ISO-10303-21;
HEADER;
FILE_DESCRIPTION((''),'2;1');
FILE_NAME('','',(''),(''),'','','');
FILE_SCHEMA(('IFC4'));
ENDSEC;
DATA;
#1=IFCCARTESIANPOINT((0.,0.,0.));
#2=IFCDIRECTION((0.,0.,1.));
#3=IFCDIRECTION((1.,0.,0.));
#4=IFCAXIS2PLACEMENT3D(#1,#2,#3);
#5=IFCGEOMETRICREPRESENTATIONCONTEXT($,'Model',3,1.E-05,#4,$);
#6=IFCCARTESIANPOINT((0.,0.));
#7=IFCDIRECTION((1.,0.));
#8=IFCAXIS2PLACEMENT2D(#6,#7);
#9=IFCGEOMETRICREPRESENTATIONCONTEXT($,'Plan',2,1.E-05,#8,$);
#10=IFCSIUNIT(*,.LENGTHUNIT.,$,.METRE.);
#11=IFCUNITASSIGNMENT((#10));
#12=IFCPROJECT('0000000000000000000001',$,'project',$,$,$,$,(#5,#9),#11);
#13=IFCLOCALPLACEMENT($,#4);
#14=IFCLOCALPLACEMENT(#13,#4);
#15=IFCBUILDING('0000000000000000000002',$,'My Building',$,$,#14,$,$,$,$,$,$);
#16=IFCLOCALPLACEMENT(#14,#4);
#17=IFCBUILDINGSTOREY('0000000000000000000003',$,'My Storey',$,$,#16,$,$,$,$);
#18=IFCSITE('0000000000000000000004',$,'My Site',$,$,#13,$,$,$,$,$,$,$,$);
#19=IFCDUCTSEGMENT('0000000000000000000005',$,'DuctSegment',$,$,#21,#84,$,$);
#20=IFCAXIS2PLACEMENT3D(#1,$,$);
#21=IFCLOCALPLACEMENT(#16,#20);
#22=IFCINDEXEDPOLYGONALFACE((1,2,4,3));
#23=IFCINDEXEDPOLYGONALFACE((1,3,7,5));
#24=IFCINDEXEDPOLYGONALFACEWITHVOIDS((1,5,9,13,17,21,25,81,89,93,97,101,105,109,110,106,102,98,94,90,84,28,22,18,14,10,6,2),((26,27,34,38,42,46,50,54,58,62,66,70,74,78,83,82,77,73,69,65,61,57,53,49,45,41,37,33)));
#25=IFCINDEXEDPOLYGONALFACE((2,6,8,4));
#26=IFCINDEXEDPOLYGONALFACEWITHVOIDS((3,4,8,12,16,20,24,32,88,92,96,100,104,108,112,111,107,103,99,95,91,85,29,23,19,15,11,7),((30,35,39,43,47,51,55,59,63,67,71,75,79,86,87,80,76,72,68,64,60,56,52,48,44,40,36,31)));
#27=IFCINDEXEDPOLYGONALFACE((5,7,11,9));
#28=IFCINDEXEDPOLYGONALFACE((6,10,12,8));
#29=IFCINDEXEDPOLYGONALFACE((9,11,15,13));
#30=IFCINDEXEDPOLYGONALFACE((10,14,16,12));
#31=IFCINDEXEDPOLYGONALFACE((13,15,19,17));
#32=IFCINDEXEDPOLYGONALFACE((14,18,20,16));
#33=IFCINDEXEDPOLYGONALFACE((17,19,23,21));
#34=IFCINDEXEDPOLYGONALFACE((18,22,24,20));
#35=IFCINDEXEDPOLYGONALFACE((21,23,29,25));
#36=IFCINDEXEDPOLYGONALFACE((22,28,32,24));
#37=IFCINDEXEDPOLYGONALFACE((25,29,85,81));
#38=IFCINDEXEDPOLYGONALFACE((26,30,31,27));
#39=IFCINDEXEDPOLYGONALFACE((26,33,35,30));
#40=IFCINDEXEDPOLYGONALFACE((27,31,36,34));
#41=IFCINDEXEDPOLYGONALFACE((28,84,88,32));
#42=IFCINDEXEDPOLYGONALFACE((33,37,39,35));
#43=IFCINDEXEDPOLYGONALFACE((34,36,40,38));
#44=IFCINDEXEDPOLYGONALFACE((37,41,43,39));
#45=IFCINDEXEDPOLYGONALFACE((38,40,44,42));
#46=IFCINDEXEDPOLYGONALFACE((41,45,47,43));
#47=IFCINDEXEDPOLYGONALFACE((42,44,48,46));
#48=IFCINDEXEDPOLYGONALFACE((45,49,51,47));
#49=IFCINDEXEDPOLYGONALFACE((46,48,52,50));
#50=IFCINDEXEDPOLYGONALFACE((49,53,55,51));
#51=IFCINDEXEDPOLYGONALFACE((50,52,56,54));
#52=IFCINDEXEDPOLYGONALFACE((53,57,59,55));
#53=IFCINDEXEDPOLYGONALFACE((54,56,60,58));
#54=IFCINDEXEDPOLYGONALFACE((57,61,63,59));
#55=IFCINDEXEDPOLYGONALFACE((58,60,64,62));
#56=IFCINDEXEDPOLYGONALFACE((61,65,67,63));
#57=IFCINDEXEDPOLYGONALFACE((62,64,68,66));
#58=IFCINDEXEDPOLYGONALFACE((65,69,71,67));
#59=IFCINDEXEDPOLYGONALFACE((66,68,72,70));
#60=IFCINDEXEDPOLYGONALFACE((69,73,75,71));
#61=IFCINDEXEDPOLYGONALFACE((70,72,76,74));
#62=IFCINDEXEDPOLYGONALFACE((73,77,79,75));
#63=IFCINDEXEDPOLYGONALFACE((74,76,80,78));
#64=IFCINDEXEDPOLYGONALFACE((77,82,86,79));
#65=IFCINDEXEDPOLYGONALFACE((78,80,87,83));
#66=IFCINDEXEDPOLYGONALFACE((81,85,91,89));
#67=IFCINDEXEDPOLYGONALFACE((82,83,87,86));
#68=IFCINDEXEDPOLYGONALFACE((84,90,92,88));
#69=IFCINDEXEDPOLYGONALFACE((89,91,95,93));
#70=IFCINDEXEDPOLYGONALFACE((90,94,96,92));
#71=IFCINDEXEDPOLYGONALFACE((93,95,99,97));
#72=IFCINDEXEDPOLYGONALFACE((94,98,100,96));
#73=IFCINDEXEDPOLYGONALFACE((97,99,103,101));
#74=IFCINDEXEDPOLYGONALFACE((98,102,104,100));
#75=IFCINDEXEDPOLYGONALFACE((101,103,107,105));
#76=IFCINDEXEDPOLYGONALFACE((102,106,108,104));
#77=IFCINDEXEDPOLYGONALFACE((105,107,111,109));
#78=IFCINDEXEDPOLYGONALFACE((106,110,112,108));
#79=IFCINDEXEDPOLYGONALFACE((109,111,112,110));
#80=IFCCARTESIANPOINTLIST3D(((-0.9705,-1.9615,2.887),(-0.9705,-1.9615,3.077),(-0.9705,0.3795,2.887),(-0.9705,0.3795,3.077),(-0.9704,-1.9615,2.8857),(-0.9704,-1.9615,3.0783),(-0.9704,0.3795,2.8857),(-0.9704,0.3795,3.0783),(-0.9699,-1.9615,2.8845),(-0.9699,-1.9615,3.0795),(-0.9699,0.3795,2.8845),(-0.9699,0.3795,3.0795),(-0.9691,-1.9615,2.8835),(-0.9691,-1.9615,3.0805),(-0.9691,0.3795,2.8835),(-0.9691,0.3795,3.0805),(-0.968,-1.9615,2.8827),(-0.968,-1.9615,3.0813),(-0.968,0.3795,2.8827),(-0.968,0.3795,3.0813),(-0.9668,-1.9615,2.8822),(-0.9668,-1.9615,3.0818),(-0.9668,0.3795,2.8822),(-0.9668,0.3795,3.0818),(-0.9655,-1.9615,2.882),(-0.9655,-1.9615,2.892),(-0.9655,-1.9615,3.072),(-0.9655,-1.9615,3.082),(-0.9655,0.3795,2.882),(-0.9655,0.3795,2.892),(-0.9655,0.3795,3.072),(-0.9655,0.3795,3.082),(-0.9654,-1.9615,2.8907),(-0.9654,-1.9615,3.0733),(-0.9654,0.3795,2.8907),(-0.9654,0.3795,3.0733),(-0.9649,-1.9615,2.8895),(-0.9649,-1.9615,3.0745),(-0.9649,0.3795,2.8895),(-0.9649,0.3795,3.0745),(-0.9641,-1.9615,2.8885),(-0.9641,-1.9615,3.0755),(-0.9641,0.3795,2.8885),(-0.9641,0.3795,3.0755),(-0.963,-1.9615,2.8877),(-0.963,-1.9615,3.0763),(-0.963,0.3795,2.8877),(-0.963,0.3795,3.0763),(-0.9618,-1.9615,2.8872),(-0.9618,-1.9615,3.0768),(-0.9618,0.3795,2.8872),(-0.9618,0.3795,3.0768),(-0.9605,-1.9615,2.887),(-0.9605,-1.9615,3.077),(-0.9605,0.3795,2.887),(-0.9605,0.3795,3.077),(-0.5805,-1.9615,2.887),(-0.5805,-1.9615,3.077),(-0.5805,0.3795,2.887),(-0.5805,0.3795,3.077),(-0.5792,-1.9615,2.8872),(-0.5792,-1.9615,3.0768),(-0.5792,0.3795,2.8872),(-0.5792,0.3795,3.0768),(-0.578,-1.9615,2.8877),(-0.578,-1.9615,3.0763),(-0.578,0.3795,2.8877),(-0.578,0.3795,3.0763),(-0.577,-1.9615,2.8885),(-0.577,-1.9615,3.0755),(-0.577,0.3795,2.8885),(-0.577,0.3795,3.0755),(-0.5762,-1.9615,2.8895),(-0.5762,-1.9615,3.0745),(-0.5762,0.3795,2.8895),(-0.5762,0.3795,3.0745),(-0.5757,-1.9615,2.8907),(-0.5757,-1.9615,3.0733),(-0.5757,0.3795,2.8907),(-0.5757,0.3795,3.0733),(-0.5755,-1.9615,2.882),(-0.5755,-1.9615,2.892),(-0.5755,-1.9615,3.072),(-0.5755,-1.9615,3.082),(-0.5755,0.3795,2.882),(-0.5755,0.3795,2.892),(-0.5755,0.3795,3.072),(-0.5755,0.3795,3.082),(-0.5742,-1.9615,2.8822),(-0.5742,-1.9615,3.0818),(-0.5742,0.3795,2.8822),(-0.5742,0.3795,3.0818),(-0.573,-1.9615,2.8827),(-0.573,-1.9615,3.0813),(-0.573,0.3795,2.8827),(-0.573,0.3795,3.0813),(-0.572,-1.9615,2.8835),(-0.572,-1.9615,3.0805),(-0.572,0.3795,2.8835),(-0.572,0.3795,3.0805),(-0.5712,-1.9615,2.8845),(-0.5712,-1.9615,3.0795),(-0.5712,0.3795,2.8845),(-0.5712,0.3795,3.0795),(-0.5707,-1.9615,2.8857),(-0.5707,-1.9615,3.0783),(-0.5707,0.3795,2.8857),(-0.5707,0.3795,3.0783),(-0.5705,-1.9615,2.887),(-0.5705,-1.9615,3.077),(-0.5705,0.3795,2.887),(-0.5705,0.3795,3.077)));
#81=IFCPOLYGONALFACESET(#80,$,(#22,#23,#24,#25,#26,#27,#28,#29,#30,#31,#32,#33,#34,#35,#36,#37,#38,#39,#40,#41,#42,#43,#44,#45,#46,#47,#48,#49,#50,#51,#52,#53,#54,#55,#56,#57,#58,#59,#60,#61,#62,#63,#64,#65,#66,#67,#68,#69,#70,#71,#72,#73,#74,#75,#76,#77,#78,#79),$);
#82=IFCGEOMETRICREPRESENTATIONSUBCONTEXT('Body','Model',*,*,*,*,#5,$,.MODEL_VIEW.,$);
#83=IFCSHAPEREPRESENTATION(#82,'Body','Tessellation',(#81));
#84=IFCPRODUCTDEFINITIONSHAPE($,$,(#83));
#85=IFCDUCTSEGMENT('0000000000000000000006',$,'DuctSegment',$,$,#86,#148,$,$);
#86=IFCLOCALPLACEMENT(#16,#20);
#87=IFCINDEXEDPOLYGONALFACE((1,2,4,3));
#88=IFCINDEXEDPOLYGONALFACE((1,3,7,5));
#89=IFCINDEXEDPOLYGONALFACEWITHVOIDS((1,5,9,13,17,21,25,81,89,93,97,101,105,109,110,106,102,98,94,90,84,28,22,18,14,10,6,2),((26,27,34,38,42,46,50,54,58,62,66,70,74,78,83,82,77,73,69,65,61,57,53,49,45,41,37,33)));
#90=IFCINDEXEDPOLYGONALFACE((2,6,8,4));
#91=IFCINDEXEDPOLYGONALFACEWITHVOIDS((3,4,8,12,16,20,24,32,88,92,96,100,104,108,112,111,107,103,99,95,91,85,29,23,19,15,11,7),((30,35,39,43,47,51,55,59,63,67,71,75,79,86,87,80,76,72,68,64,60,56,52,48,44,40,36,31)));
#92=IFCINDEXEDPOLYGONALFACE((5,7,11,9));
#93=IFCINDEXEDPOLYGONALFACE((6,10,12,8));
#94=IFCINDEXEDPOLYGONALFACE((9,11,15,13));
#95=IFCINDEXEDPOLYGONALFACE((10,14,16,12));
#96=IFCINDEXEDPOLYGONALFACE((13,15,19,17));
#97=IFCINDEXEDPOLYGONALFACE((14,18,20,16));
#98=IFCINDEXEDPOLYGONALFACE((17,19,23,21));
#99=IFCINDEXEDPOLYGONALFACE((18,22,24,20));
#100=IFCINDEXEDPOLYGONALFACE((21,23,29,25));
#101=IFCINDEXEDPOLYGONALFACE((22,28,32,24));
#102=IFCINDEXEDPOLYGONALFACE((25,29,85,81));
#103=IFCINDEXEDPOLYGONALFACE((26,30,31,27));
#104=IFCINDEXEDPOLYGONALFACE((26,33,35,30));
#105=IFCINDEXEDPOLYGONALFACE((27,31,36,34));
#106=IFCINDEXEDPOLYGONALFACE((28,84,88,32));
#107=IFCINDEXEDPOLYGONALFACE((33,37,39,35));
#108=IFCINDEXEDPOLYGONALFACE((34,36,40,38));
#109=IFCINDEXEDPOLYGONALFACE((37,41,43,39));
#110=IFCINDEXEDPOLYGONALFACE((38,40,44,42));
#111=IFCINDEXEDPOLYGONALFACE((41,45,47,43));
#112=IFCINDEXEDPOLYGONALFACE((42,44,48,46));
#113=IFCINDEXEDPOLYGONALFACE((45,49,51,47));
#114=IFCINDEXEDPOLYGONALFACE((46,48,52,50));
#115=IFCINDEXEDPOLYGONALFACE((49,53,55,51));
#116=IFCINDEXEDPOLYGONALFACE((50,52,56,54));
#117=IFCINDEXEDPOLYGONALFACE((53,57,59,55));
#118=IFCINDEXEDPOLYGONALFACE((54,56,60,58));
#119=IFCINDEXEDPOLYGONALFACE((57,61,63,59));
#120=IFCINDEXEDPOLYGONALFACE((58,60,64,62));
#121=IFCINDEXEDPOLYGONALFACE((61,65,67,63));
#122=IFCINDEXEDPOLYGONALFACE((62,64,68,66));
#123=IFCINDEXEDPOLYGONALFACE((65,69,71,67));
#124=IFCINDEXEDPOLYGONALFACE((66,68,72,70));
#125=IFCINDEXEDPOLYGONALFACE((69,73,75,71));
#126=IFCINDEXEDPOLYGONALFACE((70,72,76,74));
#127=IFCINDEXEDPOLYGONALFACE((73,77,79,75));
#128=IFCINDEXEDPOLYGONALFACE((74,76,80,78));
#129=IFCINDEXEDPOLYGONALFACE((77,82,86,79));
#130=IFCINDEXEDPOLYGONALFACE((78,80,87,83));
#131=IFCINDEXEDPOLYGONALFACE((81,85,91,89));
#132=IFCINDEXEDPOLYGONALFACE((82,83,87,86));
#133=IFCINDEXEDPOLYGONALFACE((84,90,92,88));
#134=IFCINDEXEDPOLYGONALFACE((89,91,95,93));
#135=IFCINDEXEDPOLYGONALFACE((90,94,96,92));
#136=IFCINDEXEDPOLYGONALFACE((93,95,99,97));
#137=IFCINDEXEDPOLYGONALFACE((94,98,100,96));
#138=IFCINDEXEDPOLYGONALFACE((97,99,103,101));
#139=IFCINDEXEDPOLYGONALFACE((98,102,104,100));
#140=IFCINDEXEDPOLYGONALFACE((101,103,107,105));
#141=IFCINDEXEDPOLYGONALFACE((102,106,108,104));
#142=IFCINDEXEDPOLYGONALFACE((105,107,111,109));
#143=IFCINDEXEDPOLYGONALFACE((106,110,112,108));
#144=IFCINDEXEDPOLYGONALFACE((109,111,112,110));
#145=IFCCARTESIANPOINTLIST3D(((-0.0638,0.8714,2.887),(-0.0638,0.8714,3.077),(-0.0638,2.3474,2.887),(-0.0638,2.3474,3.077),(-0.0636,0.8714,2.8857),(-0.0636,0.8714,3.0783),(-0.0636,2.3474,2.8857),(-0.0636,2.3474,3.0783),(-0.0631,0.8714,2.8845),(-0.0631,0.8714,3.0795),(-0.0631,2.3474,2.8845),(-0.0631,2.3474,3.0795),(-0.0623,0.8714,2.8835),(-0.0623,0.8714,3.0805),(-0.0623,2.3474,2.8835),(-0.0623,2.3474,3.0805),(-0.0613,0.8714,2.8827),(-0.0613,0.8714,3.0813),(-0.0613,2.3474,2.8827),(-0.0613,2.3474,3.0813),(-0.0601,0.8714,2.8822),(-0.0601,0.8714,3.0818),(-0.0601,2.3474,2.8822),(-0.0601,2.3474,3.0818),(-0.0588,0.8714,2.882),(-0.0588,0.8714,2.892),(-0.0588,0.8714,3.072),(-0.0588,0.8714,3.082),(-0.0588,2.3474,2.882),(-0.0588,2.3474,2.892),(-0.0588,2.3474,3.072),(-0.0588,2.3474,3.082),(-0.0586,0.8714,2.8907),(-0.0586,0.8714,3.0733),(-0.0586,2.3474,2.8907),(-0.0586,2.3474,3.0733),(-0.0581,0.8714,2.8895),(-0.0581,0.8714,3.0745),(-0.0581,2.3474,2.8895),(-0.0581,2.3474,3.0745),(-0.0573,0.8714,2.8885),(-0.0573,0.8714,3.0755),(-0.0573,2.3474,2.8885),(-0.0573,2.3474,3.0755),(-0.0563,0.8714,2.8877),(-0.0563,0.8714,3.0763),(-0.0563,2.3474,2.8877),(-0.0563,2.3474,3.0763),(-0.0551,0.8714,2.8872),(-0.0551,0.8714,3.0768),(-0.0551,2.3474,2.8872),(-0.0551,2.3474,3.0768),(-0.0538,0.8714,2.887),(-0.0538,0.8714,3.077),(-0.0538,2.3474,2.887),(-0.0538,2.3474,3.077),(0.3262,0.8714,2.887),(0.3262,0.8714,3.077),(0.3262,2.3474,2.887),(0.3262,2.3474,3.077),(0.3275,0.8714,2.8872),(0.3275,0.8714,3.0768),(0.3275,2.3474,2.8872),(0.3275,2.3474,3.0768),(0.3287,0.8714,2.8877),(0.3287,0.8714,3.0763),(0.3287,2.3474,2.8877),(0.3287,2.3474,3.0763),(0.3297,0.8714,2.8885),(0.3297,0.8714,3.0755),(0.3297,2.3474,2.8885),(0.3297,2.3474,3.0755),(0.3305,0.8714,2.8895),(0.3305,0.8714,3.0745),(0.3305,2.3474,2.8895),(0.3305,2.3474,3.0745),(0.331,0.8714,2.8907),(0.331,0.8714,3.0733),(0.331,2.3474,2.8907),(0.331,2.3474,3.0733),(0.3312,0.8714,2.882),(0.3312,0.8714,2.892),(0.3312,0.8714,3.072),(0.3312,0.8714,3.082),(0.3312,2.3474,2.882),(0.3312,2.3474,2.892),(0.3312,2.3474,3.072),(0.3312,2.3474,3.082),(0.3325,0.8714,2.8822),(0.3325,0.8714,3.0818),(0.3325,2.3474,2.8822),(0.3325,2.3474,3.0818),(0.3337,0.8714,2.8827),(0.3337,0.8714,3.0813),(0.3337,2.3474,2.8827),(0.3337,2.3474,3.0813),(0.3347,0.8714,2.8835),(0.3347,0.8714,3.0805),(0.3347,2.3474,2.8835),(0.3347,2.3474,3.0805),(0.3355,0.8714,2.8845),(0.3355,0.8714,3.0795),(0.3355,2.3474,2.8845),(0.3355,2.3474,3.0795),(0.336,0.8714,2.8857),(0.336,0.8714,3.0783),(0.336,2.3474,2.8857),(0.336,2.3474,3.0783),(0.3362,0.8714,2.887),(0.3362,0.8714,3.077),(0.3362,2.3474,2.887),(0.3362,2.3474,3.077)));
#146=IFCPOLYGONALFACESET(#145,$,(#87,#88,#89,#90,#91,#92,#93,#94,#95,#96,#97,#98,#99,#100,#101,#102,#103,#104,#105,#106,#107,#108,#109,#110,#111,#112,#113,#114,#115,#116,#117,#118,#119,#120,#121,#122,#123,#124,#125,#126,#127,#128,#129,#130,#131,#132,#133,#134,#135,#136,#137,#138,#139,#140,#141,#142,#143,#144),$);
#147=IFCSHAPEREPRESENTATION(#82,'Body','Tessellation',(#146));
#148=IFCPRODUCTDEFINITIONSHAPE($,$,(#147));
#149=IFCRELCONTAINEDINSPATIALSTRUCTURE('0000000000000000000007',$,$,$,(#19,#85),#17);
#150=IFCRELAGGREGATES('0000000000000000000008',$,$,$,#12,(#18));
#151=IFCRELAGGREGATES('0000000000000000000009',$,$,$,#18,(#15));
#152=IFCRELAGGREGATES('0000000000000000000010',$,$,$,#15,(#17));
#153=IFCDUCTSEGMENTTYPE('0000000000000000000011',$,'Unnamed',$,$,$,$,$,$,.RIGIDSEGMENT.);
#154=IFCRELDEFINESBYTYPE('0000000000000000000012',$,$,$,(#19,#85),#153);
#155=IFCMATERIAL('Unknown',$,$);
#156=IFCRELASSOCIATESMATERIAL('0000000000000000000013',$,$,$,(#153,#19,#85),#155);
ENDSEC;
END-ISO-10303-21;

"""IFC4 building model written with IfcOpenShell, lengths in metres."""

from ifc_helpers import new_model, si_unit, frame, origin_with_axes, origin_2d_with_axis, place, context, subcontext, project, spatial, hollow_rectangle, extrude, material, material_profile, profile_set, profile_usage, type_object, element, save


model = new_model("IFC4")

# Units and contexts
model_context = context("Model", 3, precision=1e-05, world=origin_with_axes())
plan_context = context("Plan", 2, precision=1e-05, world=origin_2d_with_axis())
body_context_1 = subcontext(model_context, "Body", "Model", "MODEL_VIEW")
ifc_project = project(units=[si_unit("LENGTHUNIT", "METRE")], contexts=[model_context, plan_context])

# Site, building, storey
site_placement = place(None, origin_with_axes())
site = spatial("IfcSite", under=ifc_project, at=site_placement, Name="My Site")
building_placement = place(site_placement, origin_with_axes())
building = spatial("IfcBuilding", under=site, at=building_placement, Name="My Building")
storey_placement = place(building_placement, origin_with_axes())
storey = spatial("IfcBuildingStorey", under=building, at=storey_placement, Name="My Storey")

# Shared definitions
ifc_material = material(Name="Unknown")

# Duct segments
ifc_material_profile_1 = material_profile(ifc_material, hollow_rectangle(XDim=0.4, YDim=0.2, WallThickness=0.005, InnerFilletRadius=0.005, OuterFilletRadius=0.005))
ifc_profile_set_1 = profile_set([ifc_material_profile_1])
ifc_profile_usage_1 = profile_usage(ifc_profile_set_1, cardinal=5)
duct_segment_type = type_object("IfcDuctSegmentType", Name="Unnamed", PredefinedType="RIGIDSEGMENT", material=ifc_profile_set_1)
duct_segment_1_placement = place(storey_placement, frame((-0.7705, 0.3795, 2.982), z_axis=(0.0, -1.0, 0.0), x_axis=(1.0, 0.0, 0.0)))
element("IfcDuctSegment", 1, at=duct_segment_1_placement, inside=storey, type_object=duct_segment_type, material=ifc_profile_usage_1, Name="DuctSegment", context=body_context_1, shape_type="SweptSolid", body=[
    extrude(hollow_rectangle(XDim=0.4, YDim=0.2, WallThickness=0.005, InnerFilletRadius=0.005, OuterFilletRadius=0.005), origin_with_axes(), (0.0, 0.0, 1.0), 2.341),
])
ifc_profile_usage_2 = profile_usage(ifc_profile_set_1, cardinal=5)
duct_segment_2_placement = place(storey_placement, frame((0.1362, 0.8714, 2.982), z_axis=(0.0, 1.0, 0.0), x_axis=(-1.0, 0.0, 0.0)))
element("IfcDuctSegment", 2, at=duct_segment_2_placement, inside=storey, type_object=duct_segment_type, material=ifc_profile_usage_2, Name="DuctSegment", context=body_context_1, shape_type="SweptSolid", body=[
    extrude(hollow_rectangle(XDim=0.4, YDim=0.2, WallThickness=0.005, InnerFilletRadius=0.005, OuterFilletRadius=0.005), origin_with_axes(), (0.0, 0.0, 1.0), 1.4761),
])

save(model, "model.ifc")
